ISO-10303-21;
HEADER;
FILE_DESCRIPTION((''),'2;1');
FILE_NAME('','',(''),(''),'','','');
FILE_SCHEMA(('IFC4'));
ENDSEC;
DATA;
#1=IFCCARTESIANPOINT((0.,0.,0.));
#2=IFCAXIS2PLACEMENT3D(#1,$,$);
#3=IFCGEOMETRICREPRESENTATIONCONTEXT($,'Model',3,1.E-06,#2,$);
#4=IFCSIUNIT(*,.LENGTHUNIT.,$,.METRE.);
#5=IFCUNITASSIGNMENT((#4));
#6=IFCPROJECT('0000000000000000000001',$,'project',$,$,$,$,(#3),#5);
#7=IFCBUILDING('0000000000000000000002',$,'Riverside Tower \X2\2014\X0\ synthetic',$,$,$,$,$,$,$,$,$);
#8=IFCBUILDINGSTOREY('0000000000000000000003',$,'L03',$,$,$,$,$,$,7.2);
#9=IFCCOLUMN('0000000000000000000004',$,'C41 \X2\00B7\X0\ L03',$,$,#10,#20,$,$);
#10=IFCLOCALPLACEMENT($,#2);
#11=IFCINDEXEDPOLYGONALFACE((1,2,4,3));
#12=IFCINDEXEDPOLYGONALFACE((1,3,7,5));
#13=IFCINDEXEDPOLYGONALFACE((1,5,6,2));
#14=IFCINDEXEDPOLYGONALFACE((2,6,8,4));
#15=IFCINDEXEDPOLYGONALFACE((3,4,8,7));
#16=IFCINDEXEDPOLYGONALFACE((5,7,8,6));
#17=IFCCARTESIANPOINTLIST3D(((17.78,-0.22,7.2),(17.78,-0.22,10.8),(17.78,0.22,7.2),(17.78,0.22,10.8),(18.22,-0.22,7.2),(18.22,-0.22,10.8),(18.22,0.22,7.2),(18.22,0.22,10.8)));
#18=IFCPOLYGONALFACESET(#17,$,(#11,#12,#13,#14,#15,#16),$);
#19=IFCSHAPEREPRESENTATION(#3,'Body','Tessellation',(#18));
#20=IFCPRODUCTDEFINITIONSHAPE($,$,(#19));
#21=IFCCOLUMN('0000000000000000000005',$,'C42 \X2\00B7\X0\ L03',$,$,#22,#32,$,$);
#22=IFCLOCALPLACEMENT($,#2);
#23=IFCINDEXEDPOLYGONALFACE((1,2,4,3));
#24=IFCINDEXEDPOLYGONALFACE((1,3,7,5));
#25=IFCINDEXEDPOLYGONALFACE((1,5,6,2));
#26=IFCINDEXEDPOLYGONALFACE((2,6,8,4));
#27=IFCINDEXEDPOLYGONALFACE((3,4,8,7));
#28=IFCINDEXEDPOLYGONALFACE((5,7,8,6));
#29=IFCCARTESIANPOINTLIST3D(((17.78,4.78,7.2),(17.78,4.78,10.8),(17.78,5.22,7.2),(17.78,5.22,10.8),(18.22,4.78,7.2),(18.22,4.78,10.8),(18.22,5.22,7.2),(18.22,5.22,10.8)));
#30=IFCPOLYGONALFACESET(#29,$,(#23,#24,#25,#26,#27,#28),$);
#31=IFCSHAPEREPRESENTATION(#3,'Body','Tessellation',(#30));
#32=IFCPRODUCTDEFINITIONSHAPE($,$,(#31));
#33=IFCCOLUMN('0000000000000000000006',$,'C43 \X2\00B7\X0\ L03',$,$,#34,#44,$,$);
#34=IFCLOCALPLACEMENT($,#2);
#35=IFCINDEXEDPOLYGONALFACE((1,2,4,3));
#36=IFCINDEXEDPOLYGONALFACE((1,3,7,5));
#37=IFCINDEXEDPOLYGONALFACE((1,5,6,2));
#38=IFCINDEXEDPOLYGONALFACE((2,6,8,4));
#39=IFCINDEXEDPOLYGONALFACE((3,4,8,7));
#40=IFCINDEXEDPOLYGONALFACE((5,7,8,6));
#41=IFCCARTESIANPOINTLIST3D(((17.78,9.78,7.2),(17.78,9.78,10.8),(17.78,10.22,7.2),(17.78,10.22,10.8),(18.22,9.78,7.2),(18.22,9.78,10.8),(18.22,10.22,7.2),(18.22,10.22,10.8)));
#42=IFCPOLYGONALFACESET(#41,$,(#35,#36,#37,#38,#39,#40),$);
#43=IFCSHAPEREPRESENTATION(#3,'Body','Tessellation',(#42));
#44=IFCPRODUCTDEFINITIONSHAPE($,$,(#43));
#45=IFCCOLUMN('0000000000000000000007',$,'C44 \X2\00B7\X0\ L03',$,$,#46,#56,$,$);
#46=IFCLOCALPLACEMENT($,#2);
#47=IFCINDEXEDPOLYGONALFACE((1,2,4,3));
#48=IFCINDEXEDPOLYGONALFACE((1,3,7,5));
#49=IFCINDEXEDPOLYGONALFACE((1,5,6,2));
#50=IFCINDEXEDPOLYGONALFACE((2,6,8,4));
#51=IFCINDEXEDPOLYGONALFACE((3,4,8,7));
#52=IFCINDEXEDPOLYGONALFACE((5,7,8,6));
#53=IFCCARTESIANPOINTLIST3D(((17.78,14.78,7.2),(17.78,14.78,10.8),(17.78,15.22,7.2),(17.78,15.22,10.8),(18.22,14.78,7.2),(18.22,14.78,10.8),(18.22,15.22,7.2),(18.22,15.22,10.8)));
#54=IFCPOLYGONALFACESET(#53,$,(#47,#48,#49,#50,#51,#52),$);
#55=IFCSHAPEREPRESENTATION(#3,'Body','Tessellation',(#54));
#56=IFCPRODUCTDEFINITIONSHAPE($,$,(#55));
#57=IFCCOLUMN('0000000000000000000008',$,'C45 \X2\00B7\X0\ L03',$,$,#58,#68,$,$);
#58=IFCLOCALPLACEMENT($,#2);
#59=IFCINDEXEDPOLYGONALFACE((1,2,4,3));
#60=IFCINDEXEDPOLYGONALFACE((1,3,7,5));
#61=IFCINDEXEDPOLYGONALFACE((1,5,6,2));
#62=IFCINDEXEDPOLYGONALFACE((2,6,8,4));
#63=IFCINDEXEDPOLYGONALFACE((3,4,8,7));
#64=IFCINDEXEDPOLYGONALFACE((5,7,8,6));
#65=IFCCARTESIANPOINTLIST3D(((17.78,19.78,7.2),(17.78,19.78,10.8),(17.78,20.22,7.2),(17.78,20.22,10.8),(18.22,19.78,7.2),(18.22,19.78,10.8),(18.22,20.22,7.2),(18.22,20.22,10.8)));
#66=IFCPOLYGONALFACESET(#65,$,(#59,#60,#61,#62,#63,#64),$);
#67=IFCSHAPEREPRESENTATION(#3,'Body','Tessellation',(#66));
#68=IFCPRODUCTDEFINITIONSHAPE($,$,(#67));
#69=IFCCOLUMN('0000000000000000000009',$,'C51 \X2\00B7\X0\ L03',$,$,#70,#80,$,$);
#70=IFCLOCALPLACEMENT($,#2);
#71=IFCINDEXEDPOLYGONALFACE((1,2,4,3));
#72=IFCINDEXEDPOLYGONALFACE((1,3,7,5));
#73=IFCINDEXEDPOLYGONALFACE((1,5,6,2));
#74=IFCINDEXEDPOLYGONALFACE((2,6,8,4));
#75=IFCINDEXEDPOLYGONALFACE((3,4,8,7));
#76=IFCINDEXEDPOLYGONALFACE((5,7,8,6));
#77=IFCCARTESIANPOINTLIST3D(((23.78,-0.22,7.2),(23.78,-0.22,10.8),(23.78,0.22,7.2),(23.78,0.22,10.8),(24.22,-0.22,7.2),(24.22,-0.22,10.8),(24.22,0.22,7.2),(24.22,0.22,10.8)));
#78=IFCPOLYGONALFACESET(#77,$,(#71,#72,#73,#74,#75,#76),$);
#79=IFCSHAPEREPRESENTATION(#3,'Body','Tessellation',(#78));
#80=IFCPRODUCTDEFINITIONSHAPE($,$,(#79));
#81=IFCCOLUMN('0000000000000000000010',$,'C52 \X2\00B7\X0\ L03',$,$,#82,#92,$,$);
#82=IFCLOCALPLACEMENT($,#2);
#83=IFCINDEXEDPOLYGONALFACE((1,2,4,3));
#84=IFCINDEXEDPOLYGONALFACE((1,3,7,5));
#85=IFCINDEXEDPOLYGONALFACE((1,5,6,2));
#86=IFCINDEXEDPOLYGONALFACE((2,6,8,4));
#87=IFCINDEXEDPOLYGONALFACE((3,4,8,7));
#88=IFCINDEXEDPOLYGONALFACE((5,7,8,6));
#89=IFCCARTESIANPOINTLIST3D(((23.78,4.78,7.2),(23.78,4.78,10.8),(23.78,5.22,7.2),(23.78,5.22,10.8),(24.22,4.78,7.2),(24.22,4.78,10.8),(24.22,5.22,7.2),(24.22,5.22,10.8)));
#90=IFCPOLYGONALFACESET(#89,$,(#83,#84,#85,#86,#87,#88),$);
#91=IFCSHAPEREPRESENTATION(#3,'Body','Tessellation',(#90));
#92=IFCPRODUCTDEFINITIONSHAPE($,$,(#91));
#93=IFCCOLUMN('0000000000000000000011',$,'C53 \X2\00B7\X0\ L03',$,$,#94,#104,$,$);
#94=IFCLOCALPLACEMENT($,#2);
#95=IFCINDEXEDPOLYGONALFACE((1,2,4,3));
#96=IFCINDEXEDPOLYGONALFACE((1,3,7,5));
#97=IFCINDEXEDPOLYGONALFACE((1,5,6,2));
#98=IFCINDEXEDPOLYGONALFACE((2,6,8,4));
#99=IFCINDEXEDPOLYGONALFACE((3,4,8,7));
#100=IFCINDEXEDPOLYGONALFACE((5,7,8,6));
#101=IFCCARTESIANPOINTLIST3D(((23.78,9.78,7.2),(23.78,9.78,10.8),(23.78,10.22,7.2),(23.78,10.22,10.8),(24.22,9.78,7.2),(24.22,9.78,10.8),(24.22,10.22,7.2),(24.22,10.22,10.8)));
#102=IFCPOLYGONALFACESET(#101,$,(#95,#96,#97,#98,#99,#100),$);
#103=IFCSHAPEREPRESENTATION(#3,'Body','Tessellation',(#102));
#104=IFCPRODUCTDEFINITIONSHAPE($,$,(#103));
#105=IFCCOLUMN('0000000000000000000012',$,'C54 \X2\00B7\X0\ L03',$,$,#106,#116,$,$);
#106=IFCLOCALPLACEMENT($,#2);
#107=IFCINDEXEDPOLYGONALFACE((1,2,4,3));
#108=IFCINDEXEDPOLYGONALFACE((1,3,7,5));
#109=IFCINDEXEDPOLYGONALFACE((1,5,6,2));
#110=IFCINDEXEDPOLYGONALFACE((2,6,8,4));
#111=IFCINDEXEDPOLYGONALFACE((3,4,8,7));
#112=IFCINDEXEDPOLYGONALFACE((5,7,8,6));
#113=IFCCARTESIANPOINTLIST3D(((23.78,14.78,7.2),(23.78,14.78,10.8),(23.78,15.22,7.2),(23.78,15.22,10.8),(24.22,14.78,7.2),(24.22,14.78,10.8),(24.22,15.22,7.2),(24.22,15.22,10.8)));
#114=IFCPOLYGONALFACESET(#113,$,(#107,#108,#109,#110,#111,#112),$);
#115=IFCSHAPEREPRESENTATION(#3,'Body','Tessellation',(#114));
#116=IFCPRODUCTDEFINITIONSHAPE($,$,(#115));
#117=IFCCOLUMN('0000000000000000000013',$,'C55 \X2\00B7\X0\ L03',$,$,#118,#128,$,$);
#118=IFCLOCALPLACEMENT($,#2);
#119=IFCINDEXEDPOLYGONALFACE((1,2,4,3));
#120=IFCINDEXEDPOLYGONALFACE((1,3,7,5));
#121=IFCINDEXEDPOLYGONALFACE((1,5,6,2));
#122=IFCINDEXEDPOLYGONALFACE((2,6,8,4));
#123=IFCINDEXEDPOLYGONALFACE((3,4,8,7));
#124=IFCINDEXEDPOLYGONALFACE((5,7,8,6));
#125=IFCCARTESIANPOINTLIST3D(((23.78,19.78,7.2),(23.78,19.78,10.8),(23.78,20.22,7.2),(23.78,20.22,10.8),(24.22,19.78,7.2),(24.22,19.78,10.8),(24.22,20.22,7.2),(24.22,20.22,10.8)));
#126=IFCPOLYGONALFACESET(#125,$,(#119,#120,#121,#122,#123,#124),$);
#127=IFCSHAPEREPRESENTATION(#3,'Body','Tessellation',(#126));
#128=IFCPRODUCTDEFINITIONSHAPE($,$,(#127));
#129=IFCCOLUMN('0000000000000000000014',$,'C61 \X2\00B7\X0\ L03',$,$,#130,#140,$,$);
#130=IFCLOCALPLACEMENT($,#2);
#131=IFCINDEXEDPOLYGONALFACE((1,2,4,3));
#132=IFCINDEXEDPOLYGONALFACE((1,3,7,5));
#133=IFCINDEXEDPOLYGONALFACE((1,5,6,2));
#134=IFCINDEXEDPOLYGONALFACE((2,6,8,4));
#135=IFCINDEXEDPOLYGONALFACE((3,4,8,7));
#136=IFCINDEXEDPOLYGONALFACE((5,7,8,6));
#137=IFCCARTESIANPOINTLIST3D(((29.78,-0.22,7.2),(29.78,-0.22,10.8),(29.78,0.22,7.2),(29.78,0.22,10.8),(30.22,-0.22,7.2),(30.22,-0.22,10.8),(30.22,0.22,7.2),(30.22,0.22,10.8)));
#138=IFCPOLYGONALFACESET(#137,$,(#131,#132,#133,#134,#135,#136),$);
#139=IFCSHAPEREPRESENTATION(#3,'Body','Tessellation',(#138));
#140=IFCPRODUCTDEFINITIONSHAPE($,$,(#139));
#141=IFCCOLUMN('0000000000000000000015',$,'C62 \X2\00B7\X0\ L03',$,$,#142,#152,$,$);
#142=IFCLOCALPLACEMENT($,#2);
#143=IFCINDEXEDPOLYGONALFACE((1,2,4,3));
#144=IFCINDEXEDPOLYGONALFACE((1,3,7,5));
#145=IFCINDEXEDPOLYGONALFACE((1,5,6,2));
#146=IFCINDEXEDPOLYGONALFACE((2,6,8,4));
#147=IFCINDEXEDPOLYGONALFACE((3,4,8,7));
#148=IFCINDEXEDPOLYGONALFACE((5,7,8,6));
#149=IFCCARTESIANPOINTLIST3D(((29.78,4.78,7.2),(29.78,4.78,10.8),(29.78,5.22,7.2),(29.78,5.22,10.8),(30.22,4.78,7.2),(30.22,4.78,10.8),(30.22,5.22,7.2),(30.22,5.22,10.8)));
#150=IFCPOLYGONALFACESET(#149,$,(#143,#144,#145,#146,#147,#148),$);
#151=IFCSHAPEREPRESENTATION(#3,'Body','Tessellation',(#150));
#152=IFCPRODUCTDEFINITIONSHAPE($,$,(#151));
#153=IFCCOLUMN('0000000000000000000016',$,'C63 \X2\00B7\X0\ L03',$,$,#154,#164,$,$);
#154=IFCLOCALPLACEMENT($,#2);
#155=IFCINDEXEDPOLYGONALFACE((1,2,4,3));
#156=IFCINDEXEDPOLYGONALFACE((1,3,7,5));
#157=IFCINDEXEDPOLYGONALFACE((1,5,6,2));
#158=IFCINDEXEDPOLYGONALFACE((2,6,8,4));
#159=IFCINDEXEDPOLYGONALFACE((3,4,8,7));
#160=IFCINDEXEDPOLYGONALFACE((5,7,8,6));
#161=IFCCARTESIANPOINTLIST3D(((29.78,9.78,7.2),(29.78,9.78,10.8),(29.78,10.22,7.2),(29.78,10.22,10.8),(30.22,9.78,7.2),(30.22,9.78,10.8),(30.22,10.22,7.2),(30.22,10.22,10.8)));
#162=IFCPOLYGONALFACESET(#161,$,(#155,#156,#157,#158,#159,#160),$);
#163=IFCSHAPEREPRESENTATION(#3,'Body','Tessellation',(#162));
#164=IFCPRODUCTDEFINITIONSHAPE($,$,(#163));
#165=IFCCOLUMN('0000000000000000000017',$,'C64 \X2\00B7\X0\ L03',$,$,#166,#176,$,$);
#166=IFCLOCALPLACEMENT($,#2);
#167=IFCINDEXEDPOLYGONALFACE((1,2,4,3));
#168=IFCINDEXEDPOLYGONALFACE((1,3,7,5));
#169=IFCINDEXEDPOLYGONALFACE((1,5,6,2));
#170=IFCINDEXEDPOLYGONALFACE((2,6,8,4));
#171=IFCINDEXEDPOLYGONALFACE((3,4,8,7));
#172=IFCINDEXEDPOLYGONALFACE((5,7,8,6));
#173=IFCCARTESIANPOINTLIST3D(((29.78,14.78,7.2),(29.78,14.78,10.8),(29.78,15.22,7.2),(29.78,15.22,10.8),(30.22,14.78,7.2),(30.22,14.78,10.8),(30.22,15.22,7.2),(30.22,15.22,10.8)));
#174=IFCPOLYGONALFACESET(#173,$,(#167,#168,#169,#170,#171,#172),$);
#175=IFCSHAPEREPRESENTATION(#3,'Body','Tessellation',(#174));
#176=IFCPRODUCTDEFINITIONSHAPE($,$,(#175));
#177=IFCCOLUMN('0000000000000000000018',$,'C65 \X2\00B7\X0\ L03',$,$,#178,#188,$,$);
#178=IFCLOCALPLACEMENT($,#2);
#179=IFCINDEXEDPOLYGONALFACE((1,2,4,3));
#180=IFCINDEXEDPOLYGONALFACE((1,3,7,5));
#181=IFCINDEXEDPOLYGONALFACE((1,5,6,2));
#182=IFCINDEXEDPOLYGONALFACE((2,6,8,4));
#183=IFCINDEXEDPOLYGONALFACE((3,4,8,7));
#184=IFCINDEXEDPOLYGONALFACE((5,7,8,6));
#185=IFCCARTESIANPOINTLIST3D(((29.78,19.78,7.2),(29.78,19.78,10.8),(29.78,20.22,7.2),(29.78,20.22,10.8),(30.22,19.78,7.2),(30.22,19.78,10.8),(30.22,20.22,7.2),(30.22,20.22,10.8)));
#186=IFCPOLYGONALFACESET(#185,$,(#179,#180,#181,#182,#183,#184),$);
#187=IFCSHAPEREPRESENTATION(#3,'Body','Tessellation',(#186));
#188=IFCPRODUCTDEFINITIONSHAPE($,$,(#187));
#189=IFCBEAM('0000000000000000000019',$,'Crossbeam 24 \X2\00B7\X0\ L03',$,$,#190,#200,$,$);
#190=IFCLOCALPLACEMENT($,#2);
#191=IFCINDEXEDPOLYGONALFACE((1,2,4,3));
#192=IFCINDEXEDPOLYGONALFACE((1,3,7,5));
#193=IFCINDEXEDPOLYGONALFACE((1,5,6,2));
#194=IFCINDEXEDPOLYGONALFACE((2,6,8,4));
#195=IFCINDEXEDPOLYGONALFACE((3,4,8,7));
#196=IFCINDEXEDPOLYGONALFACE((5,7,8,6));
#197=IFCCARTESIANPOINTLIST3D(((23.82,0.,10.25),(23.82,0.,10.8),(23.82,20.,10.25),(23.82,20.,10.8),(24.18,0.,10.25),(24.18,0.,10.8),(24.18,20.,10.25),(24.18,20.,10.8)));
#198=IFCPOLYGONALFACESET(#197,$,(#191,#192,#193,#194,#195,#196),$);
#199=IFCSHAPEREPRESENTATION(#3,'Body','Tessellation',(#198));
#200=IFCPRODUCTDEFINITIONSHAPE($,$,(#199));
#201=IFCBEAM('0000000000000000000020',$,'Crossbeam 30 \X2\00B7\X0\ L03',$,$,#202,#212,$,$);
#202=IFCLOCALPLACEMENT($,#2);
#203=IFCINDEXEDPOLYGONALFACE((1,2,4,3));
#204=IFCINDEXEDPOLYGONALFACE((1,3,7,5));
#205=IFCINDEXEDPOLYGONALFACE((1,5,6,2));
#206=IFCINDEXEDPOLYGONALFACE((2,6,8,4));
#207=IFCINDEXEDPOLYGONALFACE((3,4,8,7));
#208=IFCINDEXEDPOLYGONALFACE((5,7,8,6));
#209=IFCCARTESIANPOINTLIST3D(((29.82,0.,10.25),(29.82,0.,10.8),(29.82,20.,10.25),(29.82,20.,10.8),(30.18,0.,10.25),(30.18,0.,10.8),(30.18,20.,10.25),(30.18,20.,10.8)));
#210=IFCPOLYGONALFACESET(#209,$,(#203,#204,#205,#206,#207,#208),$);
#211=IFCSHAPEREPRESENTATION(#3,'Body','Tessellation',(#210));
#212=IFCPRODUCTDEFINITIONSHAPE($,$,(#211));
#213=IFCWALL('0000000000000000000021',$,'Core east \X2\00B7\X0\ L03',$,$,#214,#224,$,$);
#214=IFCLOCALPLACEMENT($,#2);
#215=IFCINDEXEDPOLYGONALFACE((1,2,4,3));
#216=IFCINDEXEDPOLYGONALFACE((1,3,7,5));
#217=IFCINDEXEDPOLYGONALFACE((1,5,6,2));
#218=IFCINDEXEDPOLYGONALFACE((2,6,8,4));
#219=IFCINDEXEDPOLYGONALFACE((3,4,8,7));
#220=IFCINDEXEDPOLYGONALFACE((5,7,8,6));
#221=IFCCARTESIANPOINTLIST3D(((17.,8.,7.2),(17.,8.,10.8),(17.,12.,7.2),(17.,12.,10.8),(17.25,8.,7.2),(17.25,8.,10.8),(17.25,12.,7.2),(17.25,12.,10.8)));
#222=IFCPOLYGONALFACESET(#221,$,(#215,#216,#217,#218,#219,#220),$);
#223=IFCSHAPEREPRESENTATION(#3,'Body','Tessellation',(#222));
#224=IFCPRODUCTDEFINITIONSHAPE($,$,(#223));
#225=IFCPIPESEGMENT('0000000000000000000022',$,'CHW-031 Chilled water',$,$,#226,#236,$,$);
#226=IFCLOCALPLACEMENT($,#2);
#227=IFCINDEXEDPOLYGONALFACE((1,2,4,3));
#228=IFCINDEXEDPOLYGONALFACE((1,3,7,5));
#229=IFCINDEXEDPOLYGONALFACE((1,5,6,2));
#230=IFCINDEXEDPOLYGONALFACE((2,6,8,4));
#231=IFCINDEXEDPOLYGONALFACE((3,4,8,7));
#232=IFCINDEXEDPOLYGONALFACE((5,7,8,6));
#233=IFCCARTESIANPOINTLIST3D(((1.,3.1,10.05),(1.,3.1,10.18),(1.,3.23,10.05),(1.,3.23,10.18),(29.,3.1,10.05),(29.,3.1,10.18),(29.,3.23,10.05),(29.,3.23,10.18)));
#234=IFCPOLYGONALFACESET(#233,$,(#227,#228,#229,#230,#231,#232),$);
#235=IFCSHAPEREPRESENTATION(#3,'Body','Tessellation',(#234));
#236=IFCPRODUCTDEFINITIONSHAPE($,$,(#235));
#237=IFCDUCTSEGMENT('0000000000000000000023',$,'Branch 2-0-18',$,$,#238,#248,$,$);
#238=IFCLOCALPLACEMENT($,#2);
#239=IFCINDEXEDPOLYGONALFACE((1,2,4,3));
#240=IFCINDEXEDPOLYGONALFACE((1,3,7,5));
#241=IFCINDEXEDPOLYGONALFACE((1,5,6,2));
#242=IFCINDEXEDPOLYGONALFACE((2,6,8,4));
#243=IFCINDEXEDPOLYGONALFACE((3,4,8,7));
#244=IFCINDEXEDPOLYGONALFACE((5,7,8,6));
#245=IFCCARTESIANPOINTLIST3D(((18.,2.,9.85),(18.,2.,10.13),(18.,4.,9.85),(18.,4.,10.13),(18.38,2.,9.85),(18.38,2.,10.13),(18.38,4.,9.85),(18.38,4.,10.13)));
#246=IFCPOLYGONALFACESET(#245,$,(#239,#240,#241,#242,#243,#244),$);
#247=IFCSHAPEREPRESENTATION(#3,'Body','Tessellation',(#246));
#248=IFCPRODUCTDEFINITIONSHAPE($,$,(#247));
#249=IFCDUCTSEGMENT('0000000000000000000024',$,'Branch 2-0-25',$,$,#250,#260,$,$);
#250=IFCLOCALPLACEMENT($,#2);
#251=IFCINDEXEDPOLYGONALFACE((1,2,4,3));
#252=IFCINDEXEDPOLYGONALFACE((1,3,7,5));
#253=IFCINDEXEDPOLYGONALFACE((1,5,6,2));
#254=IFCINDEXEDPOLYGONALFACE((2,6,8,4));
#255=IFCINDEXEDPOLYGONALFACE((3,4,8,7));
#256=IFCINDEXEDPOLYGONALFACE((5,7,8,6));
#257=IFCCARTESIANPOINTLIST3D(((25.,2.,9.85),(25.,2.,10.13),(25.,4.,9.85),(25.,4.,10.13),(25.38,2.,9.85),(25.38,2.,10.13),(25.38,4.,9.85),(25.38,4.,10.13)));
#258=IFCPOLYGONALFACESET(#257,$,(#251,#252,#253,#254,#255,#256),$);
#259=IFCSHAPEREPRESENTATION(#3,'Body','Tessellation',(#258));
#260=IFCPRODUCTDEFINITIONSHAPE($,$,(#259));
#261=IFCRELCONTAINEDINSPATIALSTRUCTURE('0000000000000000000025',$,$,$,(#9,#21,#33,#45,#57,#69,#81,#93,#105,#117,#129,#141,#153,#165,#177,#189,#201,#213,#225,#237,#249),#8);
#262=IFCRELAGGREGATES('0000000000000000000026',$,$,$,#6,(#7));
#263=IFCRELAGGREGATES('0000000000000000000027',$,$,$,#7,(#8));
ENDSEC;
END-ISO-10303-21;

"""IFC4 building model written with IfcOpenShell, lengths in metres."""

from ifc_helpers import new_model, si_unit, frame, origin, place, context, project, spatial, rectangle, extrude, element, save


model = new_model("IFC4")

# Units and contexts
model_context = context("Model", 3, precision=1e-06, world=origin())
ifc_project = project(units=[si_unit("LENGTHUNIT", "METRE")], contexts=[model_context])

# Building, storey
building = spatial("IfcBuilding", under=ifc_project, Name="Riverside Tower — synthetic")
storey = spatial("IfcBuildingStorey", under=building, Name="L03", Elevation=7.2)

# Columns
for number, where, name in (
    (1, (18.0, 0.0, 7.2), "C41 · L03"),
    (2, (18.0, 5.0, 7.2), "C42 · L03"),
    (3, (18.0, 10.0, 7.2), "C43 · L03"),
    (4, (18.0, 15.0, 7.2), "C44 · L03"),
    (5, (18.0, 20.0, 7.2), "C45 · L03"),
    (6, (24.0, 0.0, 7.2), "C51 · L03"),
    (7, (24.0, 5.0, 7.2), "C52 · L03"),
    (8, (24.0, 10.0, 7.2), "C53 · L03"),
    (9, (24.0, 15.0, 7.2), "C54 · L03"),
    (10, (24.0, 20.0, 7.2), "C55 · L03"),
    (11, (30.0, 0.0, 7.2), "C61 · L03"),
    (12, (30.0, 5.0, 7.2), "C62 · L03"),
    (13, (30.0, 10.0, 7.2), "C63 · L03"),
    (14, (30.0, 15.0, 7.2), "C64 · L03"),
    (15, (30.0, 20.0, 7.2), "C65 · L03"),
):
    element("IfcColumn", number, at=place(None, frame(where)), inside=storey, Name=name, context=model_context, shape_type="SweptSolid", body=[
        extrude(rectangle(XDim=0.44, YDim=0.44), origin(), (0.0, 0.0, 1.0), 3.6),
    ])

# Beams
for number, where, name in (
    (16, (24.0, 10.0, 10.25), "Crossbeam 24 · L03"),
    (17, (30.0, 10.0, 10.25), "Crossbeam 30 · L03"),
):
    element("IfcBeam", number, at=place(None, frame(where)), inside=storey, Name=name, context=model_context, shape_type="SweptSolid", body=[
        extrude(rectangle(XDim=0.36, YDim=20.0), origin(), (0.0, 0.0, 1.0), 0.55),
    ])

# Wall
wall_placement = place(None, frame((17.125, 10.0, 7.2)))
element("IfcWall", 18, at=wall_placement, inside=storey, Name="Core east · L03", context=model_context, shape_type="SweptSolid", body=[
    extrude(rectangle(XDim=0.25, YDim=4.0), origin(), (0.0, 0.0, 1.0), 3.6),
])

# Pipe segment
pipe_segment_1_placement = place(None, frame((15.0, 3.165, 10.05)))
element("IfcPipeSegment", 19, at=pipe_segment_1_placement, inside=storey, Name="CHW-031 Chilled water", context=model_context, shape_type="SweptSolid", body=[
    extrude(rectangle(XDim=28.0, YDim=0.13), origin(), (0.0, 0.0, 1.0), 0.13),
])

# Duct segments
for number, where, name in (
    (20, (18.19, 3.0, 9.85), "Branch 2-0-18"),
    (21, (25.19, 3.0, 9.85), "Branch 2-0-25"),
):
    element("IfcDuctSegment", number, at=place(None, frame(where)), inside=storey, Name=name, context=model_context, shape_type="SweptSolid", body=[
        extrude(rectangle(XDim=0.38, YDim=2.0), origin(), (0.0, 0.0, 1.0), 0.28),
    ])

save(model, "model.ifc")
